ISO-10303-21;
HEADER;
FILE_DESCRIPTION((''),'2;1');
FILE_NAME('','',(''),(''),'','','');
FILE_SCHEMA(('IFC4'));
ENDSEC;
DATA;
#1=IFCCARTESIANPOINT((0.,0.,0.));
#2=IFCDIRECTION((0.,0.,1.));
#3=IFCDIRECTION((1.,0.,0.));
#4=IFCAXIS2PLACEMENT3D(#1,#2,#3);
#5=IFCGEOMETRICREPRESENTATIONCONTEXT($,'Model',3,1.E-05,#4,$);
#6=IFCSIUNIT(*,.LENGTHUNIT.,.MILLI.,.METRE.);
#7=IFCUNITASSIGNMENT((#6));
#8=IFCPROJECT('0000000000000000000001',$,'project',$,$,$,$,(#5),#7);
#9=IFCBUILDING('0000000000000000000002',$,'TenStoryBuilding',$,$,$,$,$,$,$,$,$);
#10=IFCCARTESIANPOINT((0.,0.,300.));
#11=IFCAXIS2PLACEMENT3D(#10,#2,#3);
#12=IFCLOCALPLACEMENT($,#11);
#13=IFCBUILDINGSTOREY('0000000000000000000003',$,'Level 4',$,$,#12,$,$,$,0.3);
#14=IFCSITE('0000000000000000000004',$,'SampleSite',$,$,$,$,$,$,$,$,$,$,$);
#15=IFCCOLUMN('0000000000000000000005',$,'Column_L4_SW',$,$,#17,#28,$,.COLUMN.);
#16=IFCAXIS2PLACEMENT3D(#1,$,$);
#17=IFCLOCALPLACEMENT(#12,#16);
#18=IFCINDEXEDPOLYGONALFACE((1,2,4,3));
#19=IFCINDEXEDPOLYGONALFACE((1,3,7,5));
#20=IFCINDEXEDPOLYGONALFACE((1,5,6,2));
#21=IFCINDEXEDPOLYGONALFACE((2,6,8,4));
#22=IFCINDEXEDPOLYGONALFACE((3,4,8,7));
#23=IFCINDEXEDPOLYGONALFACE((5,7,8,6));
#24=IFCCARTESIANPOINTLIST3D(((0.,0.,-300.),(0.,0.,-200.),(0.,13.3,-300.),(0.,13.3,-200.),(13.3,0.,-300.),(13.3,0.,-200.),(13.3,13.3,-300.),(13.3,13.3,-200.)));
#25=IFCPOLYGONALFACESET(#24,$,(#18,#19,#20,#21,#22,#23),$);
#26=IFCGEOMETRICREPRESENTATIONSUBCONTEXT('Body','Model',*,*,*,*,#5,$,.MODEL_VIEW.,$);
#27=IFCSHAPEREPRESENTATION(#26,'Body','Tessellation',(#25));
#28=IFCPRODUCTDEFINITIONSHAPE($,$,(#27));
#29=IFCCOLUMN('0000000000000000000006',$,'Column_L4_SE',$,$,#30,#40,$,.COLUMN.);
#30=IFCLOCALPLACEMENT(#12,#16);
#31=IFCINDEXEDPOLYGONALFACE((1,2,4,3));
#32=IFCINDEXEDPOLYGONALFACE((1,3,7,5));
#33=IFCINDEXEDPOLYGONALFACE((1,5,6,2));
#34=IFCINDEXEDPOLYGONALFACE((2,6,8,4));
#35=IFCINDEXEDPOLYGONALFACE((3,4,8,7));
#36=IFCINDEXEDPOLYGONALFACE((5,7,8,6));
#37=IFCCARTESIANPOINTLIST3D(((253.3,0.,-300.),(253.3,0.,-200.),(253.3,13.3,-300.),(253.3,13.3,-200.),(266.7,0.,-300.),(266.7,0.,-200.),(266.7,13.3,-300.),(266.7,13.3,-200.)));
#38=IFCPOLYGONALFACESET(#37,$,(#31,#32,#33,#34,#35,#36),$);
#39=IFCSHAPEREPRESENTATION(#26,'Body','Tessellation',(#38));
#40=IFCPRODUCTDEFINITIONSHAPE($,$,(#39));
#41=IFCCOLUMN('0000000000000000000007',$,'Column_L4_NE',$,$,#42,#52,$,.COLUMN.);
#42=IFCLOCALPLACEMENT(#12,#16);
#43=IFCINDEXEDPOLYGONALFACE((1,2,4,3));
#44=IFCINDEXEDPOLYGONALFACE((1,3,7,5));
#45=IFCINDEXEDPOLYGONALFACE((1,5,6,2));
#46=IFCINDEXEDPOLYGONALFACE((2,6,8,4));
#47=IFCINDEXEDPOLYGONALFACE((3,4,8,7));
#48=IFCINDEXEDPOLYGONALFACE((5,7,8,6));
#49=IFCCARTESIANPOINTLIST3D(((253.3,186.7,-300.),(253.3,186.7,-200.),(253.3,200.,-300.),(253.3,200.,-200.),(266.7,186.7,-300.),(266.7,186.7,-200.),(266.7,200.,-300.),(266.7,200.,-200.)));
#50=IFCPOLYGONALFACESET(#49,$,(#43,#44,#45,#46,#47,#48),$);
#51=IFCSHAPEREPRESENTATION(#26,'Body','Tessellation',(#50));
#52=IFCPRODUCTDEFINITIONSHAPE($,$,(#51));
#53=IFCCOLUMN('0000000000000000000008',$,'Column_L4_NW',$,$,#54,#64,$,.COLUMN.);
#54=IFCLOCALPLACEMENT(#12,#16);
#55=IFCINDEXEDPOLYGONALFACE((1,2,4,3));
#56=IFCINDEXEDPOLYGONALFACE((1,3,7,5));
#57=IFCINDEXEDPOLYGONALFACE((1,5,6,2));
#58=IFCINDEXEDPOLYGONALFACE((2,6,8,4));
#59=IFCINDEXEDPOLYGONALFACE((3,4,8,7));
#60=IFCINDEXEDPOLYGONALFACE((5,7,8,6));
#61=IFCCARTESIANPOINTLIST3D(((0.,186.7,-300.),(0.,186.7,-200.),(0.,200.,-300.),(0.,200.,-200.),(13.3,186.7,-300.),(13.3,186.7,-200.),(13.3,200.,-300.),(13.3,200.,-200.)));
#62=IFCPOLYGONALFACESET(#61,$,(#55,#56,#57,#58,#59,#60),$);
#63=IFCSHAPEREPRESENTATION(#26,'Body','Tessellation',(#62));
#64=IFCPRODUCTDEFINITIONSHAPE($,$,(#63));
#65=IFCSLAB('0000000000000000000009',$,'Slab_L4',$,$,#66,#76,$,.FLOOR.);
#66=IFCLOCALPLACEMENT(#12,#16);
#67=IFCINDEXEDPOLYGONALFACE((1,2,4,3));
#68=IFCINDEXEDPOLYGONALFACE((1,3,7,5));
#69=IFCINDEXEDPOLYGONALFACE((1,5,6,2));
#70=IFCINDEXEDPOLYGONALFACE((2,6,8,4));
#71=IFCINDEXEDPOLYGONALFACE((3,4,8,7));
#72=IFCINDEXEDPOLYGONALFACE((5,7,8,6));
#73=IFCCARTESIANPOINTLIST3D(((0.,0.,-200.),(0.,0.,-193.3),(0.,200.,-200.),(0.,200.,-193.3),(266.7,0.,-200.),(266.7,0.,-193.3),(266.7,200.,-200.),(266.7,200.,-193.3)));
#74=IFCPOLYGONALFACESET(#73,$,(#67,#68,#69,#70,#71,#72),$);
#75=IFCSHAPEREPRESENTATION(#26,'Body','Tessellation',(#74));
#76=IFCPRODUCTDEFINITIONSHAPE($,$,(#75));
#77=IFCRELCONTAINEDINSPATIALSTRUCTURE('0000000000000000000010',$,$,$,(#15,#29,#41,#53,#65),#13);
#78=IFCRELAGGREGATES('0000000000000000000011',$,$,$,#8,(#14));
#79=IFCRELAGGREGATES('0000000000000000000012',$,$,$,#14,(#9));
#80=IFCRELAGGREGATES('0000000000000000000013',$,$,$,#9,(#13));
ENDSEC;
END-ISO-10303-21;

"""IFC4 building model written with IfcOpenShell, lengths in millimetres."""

from ifc_helpers import new_model, si_unit, frame, origin_with_axes, origin_2d, place, context, subcontext, project, spatial, indexed_curve, rectangle, outline, extrude, element, save


model = new_model("IFC4")

# Units and contexts
model_context = context("Model", 3, precision=1e-05, world=origin_with_axes())
body_context = subcontext(model_context, "Body", "Model", "MODEL_VIEW")
ifc_project = project(units=[si_unit("LENGTHUNIT", "METRE", prefix="MILLI")], contexts=[model_context])

# Site, building, storey
site = spatial("IfcSite", under=ifc_project, Name="SampleSite")
building = spatial("IfcBuilding", under=site, Name="TenStoryBuilding")
storey_placement = place(None, frame((0.0, 0.0, 300.0), z_axis=(0.0, 0.0, 1.0), x_axis=(1.0, 0.0, 0.0)))
storey = spatial("IfcBuildingStorey", under=building, at=storey_placement, Name="Level 4", Elevation=0.3)

# Columns
for number, where, z_axis, x_axis, name in (
    (1, (6.7, 6.7, -300.0), (0.0, 0.0, 1.0), (1.0, 0.0, 0.0), "Column_L4_SW"),
    (2, (260.0, 6.7, -300.0), (0.0, 0.0, 1.0), (1.0, 0.0, 0.0), "Column_L4_SE"),
    (3, (260.0, 193.3, -300.0), (0.0, 0.0, 1.0), (1.0, 0.0, 0.0), "Column_L4_NE"),
    (4, (6.7, 193.3, -300.0), (0.0, 0.0, 1.0), (1.0, 0.0, 0.0), "Column_L4_NW"),
):
    element("IfcColumn", number, at=place(storey_placement, frame(where, z_axis=z_axis, x_axis=x_axis)), inside=storey, Name=name, PredefinedType="COLUMN", context=body_context, shape_type="SweptSolid", body=[
        extrude(rectangle(XDim=13.3, YDim=13.3, at=origin_2d()), origin_with_axes(), (0.0, 0.0, 1.0), 100.0),
    ])

# Slab
slab_placement = place(storey_placement, frame((0.0, 0.0, -200.0), z_axis=(0.0, 0.0, 1.0), x_axis=(1.0, 0.0, 0.0)))
element("IfcSlab", 5, at=slab_placement, inside=storey, Name="Slab_L4", PredefinedType="FLOOR", context=body_context, shape_type="SweptSolid", body=[
    extrude(outline(indexed_curve([(0.0, 0.0), (266.7, 0.0), (266.7, 200.0), (0.0, 200.0), (0.0, 0.0)])), None, (0.0, 0.0, 1.0), 6.7),
])

save(model, "model.ifc")
